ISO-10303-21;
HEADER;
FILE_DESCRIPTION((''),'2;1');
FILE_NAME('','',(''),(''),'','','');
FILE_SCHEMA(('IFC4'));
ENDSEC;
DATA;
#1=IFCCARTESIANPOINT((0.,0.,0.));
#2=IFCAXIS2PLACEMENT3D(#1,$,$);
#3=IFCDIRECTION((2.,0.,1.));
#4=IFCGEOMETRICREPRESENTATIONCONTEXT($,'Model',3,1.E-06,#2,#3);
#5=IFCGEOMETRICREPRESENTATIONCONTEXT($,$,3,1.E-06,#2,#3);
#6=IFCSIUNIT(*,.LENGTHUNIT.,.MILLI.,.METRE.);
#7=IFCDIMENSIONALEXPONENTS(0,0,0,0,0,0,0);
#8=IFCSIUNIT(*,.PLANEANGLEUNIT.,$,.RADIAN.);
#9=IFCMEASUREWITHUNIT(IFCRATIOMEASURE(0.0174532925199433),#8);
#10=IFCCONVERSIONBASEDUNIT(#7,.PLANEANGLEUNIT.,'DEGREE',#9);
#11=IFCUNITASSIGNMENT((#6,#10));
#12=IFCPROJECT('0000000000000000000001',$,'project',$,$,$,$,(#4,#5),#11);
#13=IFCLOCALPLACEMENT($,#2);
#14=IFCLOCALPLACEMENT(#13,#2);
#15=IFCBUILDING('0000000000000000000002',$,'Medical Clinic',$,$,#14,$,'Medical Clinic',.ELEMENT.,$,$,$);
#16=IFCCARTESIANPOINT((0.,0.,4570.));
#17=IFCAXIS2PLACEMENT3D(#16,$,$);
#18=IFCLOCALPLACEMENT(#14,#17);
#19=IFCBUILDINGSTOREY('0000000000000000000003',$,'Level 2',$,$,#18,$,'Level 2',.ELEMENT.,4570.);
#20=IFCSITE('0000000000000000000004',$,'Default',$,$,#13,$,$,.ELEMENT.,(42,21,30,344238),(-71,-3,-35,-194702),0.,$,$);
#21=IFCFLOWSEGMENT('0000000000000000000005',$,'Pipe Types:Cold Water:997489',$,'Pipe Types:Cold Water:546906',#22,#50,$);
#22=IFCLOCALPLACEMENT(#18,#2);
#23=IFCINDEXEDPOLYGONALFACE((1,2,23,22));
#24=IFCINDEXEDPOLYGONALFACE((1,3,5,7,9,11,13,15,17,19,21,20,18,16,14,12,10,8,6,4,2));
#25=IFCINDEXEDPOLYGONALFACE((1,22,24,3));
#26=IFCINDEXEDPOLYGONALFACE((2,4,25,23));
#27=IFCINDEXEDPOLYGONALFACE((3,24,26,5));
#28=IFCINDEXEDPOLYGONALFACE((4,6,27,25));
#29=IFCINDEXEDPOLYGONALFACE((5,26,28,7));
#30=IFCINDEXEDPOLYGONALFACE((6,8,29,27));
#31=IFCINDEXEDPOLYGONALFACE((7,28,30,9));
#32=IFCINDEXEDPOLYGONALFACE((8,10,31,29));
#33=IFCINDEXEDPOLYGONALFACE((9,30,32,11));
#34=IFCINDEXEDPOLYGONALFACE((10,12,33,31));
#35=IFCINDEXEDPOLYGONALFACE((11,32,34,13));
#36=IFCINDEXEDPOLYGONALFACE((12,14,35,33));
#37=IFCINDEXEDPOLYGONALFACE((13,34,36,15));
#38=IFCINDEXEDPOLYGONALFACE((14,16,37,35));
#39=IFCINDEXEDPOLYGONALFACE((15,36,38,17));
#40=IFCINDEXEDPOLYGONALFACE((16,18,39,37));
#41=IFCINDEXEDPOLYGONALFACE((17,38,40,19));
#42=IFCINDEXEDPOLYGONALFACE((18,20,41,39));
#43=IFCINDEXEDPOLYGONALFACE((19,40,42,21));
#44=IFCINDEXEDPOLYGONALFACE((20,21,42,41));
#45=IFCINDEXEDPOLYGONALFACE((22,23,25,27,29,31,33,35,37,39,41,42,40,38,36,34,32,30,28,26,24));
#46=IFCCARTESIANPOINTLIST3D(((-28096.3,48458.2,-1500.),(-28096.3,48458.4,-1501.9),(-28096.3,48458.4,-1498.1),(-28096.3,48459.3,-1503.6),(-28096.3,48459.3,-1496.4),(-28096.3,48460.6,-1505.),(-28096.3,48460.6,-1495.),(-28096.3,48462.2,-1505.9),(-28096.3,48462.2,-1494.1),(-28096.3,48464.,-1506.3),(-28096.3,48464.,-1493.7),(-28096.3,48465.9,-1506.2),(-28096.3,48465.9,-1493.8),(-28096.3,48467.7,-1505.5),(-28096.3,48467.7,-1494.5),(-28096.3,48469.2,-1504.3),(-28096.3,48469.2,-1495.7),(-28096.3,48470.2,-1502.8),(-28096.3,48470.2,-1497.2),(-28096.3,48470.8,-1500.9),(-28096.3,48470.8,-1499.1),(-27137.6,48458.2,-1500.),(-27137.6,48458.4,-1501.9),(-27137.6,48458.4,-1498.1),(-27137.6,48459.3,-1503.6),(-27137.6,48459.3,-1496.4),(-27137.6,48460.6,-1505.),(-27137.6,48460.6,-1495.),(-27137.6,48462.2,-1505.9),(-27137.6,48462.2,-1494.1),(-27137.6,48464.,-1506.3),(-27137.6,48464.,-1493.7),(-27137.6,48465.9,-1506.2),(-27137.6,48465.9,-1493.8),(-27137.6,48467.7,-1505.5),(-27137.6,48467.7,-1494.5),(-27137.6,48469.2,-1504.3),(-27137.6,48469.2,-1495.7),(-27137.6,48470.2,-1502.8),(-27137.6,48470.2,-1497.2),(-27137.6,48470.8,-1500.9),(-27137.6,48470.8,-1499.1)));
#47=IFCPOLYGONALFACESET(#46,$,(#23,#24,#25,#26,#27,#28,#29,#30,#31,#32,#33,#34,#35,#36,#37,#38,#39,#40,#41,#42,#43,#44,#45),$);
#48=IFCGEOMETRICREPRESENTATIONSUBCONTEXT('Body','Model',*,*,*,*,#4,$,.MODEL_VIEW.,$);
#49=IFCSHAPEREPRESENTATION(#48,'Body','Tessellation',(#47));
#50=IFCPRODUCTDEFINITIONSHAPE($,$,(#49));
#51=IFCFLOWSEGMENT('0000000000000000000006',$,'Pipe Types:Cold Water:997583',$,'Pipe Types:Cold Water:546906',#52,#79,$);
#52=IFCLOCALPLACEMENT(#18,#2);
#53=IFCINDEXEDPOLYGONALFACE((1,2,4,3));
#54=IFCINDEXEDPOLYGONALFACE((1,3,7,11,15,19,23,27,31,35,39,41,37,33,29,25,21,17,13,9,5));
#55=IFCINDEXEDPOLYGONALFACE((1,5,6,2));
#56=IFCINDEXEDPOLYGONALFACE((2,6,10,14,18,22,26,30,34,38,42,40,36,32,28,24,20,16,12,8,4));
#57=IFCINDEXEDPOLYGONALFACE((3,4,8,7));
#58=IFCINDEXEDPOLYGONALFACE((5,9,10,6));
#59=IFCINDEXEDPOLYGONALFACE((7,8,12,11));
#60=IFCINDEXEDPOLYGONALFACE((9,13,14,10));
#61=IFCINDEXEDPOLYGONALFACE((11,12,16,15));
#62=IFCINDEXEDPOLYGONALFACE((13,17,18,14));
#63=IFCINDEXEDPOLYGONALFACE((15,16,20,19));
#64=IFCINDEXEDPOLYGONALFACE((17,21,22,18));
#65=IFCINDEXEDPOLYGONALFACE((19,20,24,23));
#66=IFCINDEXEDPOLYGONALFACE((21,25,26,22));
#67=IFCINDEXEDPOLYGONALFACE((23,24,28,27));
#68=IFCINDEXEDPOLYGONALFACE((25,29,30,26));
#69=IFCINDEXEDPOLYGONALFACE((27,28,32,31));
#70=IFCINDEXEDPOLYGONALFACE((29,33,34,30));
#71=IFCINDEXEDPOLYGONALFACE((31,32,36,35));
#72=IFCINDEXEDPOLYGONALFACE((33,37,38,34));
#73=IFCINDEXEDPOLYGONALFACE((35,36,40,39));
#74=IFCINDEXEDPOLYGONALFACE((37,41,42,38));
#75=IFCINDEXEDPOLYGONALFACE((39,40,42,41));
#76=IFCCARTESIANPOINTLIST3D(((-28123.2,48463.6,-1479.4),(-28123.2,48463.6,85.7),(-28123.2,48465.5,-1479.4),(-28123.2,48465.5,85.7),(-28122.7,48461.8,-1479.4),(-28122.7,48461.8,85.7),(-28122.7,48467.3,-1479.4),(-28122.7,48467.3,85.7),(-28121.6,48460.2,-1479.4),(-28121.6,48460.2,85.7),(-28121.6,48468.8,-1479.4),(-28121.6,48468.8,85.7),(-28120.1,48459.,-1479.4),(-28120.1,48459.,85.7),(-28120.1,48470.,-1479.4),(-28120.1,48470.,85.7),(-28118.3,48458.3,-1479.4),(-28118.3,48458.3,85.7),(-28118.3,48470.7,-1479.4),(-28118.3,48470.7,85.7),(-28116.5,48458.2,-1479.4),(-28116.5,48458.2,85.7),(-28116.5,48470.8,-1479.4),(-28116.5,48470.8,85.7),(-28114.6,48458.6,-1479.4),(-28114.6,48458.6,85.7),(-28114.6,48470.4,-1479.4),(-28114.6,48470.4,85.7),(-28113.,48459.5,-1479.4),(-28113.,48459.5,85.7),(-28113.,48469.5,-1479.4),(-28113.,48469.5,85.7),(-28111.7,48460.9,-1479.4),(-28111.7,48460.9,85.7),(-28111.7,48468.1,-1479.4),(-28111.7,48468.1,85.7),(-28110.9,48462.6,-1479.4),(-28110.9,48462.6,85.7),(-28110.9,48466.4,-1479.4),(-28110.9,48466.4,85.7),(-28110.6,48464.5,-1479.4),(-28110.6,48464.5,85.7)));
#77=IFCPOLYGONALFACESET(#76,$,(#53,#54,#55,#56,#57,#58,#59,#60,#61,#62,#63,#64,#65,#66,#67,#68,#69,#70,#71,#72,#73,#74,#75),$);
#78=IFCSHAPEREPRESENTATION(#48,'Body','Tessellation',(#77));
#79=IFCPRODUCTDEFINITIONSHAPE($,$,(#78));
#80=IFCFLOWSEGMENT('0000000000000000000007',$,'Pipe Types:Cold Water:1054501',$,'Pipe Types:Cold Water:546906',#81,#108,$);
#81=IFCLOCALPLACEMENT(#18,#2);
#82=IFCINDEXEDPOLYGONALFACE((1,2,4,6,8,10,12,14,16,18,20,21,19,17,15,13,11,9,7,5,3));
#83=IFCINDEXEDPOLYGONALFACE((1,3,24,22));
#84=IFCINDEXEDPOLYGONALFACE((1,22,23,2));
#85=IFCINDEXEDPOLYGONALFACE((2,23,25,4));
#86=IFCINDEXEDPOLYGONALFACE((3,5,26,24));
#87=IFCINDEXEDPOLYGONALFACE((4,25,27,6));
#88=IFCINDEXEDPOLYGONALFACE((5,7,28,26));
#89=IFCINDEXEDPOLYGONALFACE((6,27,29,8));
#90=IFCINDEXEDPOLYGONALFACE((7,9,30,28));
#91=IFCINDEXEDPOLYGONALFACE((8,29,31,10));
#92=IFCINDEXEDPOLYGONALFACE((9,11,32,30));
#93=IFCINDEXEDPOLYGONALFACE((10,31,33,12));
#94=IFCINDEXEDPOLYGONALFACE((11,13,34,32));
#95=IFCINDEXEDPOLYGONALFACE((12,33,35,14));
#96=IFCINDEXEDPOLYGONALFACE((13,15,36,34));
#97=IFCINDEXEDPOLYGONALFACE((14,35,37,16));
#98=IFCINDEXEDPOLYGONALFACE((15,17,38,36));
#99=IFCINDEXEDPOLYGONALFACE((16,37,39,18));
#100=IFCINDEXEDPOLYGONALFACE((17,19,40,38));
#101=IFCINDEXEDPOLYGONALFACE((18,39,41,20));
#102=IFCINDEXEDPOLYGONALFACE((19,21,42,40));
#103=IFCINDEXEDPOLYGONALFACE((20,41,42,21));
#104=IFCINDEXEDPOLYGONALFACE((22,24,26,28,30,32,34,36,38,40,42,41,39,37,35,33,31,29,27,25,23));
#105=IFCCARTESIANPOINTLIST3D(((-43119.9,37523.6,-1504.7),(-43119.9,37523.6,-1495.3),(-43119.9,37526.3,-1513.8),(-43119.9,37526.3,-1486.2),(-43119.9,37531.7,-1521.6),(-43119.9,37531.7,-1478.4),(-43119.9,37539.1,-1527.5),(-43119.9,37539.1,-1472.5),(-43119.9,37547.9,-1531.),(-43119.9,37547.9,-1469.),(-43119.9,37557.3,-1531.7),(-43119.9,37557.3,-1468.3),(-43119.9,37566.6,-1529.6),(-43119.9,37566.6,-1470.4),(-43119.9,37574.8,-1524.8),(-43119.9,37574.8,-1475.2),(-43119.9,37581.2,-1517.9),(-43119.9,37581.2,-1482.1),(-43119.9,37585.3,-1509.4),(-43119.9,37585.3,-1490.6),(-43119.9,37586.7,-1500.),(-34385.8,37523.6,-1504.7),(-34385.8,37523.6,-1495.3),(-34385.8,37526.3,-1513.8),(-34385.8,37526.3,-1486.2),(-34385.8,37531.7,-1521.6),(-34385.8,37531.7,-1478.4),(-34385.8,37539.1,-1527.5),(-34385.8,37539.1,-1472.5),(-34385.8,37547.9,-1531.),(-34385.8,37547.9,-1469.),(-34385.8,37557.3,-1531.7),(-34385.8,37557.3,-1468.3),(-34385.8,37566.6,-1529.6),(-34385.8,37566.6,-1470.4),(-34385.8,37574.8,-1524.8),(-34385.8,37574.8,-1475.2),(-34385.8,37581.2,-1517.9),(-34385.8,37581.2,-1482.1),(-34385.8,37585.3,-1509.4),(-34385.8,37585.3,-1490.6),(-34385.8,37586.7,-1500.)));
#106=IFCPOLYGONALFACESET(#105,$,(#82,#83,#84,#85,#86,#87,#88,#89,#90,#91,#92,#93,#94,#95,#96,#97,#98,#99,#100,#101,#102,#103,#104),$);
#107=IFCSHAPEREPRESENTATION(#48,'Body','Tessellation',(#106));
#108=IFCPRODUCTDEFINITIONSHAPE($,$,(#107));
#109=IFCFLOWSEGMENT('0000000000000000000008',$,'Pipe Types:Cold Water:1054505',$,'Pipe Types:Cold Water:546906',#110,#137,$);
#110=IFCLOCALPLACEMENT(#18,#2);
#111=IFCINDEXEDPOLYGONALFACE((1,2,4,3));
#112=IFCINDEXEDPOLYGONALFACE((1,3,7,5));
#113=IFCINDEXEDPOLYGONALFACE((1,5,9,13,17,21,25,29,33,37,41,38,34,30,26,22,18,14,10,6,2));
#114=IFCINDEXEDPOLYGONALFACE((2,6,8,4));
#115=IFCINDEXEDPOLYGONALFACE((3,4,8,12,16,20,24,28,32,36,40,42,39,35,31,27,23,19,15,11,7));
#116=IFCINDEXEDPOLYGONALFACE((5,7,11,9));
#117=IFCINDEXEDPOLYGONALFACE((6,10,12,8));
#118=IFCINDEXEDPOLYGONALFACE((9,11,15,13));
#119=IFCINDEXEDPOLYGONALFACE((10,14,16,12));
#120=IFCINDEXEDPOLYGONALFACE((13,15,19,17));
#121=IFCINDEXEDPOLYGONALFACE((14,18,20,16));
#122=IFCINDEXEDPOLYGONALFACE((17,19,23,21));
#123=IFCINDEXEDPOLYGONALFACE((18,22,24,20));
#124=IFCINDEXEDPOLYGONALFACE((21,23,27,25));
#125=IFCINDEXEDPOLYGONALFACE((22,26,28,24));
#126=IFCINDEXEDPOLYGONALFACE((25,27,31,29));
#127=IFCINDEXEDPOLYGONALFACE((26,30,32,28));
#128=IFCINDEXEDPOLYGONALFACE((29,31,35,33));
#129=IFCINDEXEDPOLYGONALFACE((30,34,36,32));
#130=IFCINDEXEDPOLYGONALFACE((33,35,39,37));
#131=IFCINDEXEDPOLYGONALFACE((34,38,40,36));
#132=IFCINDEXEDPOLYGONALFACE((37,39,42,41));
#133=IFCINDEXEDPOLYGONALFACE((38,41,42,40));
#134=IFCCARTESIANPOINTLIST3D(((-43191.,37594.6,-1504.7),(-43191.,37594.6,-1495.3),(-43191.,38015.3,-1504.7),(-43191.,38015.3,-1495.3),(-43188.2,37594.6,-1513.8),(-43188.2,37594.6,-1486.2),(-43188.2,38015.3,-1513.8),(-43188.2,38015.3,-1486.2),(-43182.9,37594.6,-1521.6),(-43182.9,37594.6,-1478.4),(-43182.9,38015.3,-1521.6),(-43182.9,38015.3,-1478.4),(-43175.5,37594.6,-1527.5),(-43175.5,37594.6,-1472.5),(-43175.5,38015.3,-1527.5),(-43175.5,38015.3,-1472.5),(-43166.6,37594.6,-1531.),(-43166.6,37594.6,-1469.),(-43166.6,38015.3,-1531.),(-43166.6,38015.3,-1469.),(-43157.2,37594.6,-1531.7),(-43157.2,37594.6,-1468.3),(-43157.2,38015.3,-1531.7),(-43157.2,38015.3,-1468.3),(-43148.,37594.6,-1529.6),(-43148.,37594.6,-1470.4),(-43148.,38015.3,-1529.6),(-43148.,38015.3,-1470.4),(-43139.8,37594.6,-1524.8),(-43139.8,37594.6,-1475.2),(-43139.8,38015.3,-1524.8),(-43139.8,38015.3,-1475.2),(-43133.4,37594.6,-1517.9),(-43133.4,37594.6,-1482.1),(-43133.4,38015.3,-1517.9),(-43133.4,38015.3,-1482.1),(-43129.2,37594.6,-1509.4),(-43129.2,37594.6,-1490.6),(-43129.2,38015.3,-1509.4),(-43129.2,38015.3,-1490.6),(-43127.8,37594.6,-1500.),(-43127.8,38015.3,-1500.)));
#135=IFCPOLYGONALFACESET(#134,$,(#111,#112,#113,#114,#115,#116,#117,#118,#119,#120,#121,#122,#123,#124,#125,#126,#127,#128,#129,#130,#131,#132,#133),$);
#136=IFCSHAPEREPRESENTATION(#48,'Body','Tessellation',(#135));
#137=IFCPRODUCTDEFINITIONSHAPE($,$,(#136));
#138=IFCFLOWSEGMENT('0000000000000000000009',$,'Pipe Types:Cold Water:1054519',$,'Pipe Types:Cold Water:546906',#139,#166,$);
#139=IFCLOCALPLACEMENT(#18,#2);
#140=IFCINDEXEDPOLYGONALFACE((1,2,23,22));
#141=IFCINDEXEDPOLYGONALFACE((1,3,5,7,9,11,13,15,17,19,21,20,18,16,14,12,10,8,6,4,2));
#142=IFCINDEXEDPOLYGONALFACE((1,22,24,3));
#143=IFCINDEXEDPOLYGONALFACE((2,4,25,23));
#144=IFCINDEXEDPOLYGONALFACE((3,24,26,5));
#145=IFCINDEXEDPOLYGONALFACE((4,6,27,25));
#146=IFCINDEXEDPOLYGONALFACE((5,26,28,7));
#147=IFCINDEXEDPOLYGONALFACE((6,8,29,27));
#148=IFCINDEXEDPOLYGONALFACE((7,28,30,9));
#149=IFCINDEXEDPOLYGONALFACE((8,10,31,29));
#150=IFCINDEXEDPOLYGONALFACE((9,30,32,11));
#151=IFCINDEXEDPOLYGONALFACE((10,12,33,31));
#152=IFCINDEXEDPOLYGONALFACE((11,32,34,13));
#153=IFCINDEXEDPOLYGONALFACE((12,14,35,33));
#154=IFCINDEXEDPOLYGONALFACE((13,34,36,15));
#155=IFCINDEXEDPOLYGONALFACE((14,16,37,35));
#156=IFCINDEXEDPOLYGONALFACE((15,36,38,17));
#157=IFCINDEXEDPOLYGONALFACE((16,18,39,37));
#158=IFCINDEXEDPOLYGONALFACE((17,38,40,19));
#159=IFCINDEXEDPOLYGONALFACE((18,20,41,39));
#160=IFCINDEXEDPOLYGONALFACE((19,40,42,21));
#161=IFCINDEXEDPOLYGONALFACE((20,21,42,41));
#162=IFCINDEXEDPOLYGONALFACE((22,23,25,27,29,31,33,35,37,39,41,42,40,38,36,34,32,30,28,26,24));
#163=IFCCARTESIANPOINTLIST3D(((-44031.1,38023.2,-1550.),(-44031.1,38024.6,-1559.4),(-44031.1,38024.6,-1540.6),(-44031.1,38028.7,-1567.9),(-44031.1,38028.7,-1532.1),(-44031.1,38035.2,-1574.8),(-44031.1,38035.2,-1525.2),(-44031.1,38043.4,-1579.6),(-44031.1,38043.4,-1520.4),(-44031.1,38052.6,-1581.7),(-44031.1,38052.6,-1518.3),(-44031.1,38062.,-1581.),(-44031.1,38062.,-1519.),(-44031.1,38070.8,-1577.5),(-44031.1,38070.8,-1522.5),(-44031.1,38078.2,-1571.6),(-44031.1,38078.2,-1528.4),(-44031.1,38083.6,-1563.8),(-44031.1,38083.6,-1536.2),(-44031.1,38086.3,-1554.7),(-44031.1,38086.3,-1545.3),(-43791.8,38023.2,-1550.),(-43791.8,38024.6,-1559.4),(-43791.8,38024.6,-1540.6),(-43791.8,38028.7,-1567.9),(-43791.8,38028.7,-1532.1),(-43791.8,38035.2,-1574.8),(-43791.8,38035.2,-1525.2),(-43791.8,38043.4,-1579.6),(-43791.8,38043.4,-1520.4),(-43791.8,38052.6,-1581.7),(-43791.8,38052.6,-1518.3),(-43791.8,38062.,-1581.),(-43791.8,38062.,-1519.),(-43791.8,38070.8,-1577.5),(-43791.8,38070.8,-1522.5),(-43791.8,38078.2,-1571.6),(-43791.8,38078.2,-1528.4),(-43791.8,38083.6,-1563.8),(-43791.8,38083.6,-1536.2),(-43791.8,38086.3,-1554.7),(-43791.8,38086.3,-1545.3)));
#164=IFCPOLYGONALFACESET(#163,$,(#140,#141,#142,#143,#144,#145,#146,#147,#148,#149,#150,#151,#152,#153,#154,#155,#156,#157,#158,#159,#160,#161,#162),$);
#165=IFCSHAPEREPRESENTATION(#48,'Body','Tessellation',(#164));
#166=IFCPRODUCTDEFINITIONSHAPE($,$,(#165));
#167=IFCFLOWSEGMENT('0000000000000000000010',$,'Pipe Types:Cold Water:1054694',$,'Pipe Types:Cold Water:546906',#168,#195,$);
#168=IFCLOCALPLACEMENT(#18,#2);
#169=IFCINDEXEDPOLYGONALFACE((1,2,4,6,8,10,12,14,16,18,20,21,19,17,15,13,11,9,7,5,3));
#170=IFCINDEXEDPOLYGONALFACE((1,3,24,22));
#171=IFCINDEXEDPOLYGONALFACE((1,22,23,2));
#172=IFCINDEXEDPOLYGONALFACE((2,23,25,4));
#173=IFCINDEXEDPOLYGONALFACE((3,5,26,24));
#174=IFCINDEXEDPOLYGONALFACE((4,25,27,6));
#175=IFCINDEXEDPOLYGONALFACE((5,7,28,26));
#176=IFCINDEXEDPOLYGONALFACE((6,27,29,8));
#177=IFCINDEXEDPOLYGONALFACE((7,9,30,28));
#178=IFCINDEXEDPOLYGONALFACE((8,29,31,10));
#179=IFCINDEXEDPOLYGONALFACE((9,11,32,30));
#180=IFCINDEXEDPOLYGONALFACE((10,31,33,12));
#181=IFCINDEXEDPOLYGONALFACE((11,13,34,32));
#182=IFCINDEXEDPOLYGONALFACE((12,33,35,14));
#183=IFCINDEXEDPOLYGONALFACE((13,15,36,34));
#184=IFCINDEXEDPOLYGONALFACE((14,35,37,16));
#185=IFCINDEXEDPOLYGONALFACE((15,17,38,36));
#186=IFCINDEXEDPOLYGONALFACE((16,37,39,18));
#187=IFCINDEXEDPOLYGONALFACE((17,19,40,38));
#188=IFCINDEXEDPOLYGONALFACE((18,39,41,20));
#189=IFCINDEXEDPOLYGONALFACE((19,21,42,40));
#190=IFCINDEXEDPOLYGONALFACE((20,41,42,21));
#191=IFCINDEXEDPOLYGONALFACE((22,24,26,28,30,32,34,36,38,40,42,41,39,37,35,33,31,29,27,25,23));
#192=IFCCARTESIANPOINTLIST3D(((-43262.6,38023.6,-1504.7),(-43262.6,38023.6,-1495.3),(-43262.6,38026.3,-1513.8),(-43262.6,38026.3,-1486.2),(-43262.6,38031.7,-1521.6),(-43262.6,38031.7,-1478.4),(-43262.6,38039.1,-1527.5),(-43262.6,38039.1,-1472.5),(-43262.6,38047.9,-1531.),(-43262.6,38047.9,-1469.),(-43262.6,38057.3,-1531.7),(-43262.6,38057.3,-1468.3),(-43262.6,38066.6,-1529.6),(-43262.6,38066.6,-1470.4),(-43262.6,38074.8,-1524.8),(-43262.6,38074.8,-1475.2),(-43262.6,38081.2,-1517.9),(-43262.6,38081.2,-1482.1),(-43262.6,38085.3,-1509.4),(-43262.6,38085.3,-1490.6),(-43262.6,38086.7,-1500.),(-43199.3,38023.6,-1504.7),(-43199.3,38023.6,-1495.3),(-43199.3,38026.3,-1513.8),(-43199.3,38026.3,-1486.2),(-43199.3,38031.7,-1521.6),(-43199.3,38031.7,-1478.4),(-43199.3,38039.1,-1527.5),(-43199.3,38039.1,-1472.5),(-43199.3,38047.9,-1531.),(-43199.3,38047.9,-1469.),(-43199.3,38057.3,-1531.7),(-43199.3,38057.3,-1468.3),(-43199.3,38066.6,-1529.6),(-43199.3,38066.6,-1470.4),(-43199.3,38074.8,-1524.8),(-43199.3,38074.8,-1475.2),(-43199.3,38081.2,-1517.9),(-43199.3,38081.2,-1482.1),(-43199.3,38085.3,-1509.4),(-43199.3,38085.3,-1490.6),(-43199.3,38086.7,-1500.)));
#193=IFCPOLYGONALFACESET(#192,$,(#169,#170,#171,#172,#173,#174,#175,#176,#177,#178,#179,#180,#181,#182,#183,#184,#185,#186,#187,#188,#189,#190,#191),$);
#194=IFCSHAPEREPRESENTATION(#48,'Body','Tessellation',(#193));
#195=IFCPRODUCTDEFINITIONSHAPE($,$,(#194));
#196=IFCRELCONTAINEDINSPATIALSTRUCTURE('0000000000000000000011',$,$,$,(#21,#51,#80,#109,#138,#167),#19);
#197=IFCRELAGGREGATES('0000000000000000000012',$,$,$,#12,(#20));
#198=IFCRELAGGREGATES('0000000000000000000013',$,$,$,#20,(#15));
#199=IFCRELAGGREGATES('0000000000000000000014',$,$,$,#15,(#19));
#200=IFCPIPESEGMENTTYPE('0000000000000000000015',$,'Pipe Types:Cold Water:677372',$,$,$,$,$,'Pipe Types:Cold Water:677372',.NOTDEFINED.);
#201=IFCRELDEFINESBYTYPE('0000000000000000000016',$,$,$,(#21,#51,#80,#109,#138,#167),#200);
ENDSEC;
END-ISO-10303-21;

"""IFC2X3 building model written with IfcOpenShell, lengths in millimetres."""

from ifc_helpers import new_model, entity, si_unit, converted_unit, direction, frame, frame_2d, origin, origin_2d_with_axis, place, context, subcontext, project, spatial, circle, extrude, type_object, element, save


model = new_model("IFC2X3")

# Units and contexts
model_context = context("Model", 3, precision=1e-06, world=origin(), true_north=direction((2.0, 0.0, 1.0)))
context_of_model = context(None, 3, precision=1e-06, world=origin(), true_north=direction((2.0, 0.0, 1.0)))
body_context = subcontext(model_context, "Body", "Model", "MODEL_VIEW")
ifc_project = project(units=[si_unit("LENGTHUNIT", "METRE", prefix="MILLI"), converted_unit("PLANEANGLEUNIT", "DEGREE", entity("IfcRatioMeasure", 0.0174532925199433), si_unit("PLANEANGLEUNIT", "RADIAN"), dimensions=[0, 0, 0, 0, 0, 0, 0])], contexts=[model_context, context_of_model])

# Site, building, storey
site_placement = place(None, origin())
site = spatial("IfcSite", under=ifc_project, at=site_placement, Name="Default", CompositionType="ELEMENT", RefLatitude=(42, 21, 30, 344238), RefLongitude=(-71, -3, -35, -194702), RefElevation=0.0)
building_placement = place(site_placement, origin())
building = spatial("IfcBuilding", under=site, at=building_placement, Name="Medical Clinic", LongName="Medical Clinic", CompositionType="ELEMENT")
storey_placement = place(building_placement, frame((0.0, 0.0, 4570.0)))
storey = spatial("IfcBuildingStorey", under=building, at=storey_placement, Name="Level 2", LongName="Level 2", CompositionType="ELEMENT", Elevation=4570.0)

# Flow segments
pipe_segment_type_1 = type_object("IfcPipeSegmentType", Name="Pipe Types:Cold Water:677372", ElementType="Pipe Types:Cold Water:677372", PredefinedType="NOTDEFINED")
flow_segment_1_placement = place(storey_placement, origin())
element("IfcFlowSegment", 1, at=flow_segment_1_placement, inside=storey, type_object=pipe_segment_type_1, Name="Pipe Types:Cold Water:997489", ObjectType="Pipe Types:Cold Water:546906", context=body_context, shape_type="SweptSolid", body=[
    extrude(circle(Radius=6.3, at=origin_2d_with_axis()), frame((-28096.3, 48464.5, -1500.0), z_axis=(1.0, 0.0, 0.0), x_axis=(0.0, -1.0, 0.0)), (0.0, 0.0, 1.0), 958.7),
])
flow_segment_2_placement = place(storey_placement, origin())
element("IfcFlowSegment", 2, at=flow_segment_2_placement, inside=storey, type_object=pipe_segment_type_1, Name="Pipe Types:Cold Water:997583", ObjectType="Pipe Types:Cold Water:546906", context=body_context, shape_type="SweptSolid", body=[
    extrude(circle(Radius=6.3, at=origin_2d_with_axis()), frame((-28116.9, 48464.5, -1479.4)), (0.0, 0.0, 1.0), 1565.1),
])
flow_segment_3_placement = place(storey_placement, origin())
element("IfcFlowSegment", 3, at=flow_segment_3_placement, inside=storey, type_object=pipe_segment_type_1, Name="Pipe Types:Cold Water:1054501", ObjectType="Pipe Types:Cold Water:546906", context=body_context, shape_type="SweptSolid", body=[
    extrude(circle(Radius=31.8, at=origin_2d_with_axis()), frame((-43119.9, 37555.0, -1500.0), z_axis=(1.0, 0.0, 0.0), x_axis=(0.0, 1.0, 0.0)), (0.0, 0.0, 1.0), 8734.1),
])
flow_segment_4_placement = place(storey_placement, origin())
element("IfcFlowSegment", 4, at=flow_segment_4_placement, inside=storey, type_object=pipe_segment_type_1, Name="Pipe Types:Cold Water:1054505", ObjectType="Pipe Types:Cold Water:546906", context=body_context, shape_type="SweptSolid", body=[
    extrude(circle(Radius=31.8, at=origin_2d_with_axis()), frame((-43159.6, 37594.6, -1500.0), z_axis=(0.0, 1.0, 0.0), x_axis=(1.0, 0.0, 0.0)), (0.0, 0.0, 1.0), 420.6),
])
flow_segment_5_placement = place(storey_placement, origin())
element("IfcFlowSegment", 5, at=flow_segment_5_placement, inside=storey, type_object=pipe_segment_type_1, Name="Pipe Types:Cold Water:1054519", ObjectType="Pipe Types:Cold Water:546906", context=body_context, shape_type="SweptSolid", body=[
    extrude(circle(Radius=31.8, at=origin_2d_with_axis()), frame((-44031.1, 38055.0, -1550.0), z_axis=(1.0, 0.0, 0.0), x_axis=(0.0, -1.0, 0.0)), (0.0, 0.0, 1.0), 239.3),
])
flow_segment_6_placement = place(storey_placement, origin())
element("IfcFlowSegment", 6, at=flow_segment_6_placement, inside=storey, type_object=pipe_segment_type_1, Name="Pipe Types:Cold Water:1054694", ObjectType="Pipe Types:Cold Water:546906", context=body_context, shape_type="SweptSolid", body=[
    extrude(circle(Radius=31.8, at=frame_2d((0.0, 0.0), x_axis=(1.0, 0.0))), frame((-43262.6, 38055.0, -1500.0), z_axis=(1.0, 0.0, 0.0), x_axis=(0.0, 1.0, 0.0)), (0.0, 0.0, 1.0), 63.3),
])

save(model, "model.ifc")
